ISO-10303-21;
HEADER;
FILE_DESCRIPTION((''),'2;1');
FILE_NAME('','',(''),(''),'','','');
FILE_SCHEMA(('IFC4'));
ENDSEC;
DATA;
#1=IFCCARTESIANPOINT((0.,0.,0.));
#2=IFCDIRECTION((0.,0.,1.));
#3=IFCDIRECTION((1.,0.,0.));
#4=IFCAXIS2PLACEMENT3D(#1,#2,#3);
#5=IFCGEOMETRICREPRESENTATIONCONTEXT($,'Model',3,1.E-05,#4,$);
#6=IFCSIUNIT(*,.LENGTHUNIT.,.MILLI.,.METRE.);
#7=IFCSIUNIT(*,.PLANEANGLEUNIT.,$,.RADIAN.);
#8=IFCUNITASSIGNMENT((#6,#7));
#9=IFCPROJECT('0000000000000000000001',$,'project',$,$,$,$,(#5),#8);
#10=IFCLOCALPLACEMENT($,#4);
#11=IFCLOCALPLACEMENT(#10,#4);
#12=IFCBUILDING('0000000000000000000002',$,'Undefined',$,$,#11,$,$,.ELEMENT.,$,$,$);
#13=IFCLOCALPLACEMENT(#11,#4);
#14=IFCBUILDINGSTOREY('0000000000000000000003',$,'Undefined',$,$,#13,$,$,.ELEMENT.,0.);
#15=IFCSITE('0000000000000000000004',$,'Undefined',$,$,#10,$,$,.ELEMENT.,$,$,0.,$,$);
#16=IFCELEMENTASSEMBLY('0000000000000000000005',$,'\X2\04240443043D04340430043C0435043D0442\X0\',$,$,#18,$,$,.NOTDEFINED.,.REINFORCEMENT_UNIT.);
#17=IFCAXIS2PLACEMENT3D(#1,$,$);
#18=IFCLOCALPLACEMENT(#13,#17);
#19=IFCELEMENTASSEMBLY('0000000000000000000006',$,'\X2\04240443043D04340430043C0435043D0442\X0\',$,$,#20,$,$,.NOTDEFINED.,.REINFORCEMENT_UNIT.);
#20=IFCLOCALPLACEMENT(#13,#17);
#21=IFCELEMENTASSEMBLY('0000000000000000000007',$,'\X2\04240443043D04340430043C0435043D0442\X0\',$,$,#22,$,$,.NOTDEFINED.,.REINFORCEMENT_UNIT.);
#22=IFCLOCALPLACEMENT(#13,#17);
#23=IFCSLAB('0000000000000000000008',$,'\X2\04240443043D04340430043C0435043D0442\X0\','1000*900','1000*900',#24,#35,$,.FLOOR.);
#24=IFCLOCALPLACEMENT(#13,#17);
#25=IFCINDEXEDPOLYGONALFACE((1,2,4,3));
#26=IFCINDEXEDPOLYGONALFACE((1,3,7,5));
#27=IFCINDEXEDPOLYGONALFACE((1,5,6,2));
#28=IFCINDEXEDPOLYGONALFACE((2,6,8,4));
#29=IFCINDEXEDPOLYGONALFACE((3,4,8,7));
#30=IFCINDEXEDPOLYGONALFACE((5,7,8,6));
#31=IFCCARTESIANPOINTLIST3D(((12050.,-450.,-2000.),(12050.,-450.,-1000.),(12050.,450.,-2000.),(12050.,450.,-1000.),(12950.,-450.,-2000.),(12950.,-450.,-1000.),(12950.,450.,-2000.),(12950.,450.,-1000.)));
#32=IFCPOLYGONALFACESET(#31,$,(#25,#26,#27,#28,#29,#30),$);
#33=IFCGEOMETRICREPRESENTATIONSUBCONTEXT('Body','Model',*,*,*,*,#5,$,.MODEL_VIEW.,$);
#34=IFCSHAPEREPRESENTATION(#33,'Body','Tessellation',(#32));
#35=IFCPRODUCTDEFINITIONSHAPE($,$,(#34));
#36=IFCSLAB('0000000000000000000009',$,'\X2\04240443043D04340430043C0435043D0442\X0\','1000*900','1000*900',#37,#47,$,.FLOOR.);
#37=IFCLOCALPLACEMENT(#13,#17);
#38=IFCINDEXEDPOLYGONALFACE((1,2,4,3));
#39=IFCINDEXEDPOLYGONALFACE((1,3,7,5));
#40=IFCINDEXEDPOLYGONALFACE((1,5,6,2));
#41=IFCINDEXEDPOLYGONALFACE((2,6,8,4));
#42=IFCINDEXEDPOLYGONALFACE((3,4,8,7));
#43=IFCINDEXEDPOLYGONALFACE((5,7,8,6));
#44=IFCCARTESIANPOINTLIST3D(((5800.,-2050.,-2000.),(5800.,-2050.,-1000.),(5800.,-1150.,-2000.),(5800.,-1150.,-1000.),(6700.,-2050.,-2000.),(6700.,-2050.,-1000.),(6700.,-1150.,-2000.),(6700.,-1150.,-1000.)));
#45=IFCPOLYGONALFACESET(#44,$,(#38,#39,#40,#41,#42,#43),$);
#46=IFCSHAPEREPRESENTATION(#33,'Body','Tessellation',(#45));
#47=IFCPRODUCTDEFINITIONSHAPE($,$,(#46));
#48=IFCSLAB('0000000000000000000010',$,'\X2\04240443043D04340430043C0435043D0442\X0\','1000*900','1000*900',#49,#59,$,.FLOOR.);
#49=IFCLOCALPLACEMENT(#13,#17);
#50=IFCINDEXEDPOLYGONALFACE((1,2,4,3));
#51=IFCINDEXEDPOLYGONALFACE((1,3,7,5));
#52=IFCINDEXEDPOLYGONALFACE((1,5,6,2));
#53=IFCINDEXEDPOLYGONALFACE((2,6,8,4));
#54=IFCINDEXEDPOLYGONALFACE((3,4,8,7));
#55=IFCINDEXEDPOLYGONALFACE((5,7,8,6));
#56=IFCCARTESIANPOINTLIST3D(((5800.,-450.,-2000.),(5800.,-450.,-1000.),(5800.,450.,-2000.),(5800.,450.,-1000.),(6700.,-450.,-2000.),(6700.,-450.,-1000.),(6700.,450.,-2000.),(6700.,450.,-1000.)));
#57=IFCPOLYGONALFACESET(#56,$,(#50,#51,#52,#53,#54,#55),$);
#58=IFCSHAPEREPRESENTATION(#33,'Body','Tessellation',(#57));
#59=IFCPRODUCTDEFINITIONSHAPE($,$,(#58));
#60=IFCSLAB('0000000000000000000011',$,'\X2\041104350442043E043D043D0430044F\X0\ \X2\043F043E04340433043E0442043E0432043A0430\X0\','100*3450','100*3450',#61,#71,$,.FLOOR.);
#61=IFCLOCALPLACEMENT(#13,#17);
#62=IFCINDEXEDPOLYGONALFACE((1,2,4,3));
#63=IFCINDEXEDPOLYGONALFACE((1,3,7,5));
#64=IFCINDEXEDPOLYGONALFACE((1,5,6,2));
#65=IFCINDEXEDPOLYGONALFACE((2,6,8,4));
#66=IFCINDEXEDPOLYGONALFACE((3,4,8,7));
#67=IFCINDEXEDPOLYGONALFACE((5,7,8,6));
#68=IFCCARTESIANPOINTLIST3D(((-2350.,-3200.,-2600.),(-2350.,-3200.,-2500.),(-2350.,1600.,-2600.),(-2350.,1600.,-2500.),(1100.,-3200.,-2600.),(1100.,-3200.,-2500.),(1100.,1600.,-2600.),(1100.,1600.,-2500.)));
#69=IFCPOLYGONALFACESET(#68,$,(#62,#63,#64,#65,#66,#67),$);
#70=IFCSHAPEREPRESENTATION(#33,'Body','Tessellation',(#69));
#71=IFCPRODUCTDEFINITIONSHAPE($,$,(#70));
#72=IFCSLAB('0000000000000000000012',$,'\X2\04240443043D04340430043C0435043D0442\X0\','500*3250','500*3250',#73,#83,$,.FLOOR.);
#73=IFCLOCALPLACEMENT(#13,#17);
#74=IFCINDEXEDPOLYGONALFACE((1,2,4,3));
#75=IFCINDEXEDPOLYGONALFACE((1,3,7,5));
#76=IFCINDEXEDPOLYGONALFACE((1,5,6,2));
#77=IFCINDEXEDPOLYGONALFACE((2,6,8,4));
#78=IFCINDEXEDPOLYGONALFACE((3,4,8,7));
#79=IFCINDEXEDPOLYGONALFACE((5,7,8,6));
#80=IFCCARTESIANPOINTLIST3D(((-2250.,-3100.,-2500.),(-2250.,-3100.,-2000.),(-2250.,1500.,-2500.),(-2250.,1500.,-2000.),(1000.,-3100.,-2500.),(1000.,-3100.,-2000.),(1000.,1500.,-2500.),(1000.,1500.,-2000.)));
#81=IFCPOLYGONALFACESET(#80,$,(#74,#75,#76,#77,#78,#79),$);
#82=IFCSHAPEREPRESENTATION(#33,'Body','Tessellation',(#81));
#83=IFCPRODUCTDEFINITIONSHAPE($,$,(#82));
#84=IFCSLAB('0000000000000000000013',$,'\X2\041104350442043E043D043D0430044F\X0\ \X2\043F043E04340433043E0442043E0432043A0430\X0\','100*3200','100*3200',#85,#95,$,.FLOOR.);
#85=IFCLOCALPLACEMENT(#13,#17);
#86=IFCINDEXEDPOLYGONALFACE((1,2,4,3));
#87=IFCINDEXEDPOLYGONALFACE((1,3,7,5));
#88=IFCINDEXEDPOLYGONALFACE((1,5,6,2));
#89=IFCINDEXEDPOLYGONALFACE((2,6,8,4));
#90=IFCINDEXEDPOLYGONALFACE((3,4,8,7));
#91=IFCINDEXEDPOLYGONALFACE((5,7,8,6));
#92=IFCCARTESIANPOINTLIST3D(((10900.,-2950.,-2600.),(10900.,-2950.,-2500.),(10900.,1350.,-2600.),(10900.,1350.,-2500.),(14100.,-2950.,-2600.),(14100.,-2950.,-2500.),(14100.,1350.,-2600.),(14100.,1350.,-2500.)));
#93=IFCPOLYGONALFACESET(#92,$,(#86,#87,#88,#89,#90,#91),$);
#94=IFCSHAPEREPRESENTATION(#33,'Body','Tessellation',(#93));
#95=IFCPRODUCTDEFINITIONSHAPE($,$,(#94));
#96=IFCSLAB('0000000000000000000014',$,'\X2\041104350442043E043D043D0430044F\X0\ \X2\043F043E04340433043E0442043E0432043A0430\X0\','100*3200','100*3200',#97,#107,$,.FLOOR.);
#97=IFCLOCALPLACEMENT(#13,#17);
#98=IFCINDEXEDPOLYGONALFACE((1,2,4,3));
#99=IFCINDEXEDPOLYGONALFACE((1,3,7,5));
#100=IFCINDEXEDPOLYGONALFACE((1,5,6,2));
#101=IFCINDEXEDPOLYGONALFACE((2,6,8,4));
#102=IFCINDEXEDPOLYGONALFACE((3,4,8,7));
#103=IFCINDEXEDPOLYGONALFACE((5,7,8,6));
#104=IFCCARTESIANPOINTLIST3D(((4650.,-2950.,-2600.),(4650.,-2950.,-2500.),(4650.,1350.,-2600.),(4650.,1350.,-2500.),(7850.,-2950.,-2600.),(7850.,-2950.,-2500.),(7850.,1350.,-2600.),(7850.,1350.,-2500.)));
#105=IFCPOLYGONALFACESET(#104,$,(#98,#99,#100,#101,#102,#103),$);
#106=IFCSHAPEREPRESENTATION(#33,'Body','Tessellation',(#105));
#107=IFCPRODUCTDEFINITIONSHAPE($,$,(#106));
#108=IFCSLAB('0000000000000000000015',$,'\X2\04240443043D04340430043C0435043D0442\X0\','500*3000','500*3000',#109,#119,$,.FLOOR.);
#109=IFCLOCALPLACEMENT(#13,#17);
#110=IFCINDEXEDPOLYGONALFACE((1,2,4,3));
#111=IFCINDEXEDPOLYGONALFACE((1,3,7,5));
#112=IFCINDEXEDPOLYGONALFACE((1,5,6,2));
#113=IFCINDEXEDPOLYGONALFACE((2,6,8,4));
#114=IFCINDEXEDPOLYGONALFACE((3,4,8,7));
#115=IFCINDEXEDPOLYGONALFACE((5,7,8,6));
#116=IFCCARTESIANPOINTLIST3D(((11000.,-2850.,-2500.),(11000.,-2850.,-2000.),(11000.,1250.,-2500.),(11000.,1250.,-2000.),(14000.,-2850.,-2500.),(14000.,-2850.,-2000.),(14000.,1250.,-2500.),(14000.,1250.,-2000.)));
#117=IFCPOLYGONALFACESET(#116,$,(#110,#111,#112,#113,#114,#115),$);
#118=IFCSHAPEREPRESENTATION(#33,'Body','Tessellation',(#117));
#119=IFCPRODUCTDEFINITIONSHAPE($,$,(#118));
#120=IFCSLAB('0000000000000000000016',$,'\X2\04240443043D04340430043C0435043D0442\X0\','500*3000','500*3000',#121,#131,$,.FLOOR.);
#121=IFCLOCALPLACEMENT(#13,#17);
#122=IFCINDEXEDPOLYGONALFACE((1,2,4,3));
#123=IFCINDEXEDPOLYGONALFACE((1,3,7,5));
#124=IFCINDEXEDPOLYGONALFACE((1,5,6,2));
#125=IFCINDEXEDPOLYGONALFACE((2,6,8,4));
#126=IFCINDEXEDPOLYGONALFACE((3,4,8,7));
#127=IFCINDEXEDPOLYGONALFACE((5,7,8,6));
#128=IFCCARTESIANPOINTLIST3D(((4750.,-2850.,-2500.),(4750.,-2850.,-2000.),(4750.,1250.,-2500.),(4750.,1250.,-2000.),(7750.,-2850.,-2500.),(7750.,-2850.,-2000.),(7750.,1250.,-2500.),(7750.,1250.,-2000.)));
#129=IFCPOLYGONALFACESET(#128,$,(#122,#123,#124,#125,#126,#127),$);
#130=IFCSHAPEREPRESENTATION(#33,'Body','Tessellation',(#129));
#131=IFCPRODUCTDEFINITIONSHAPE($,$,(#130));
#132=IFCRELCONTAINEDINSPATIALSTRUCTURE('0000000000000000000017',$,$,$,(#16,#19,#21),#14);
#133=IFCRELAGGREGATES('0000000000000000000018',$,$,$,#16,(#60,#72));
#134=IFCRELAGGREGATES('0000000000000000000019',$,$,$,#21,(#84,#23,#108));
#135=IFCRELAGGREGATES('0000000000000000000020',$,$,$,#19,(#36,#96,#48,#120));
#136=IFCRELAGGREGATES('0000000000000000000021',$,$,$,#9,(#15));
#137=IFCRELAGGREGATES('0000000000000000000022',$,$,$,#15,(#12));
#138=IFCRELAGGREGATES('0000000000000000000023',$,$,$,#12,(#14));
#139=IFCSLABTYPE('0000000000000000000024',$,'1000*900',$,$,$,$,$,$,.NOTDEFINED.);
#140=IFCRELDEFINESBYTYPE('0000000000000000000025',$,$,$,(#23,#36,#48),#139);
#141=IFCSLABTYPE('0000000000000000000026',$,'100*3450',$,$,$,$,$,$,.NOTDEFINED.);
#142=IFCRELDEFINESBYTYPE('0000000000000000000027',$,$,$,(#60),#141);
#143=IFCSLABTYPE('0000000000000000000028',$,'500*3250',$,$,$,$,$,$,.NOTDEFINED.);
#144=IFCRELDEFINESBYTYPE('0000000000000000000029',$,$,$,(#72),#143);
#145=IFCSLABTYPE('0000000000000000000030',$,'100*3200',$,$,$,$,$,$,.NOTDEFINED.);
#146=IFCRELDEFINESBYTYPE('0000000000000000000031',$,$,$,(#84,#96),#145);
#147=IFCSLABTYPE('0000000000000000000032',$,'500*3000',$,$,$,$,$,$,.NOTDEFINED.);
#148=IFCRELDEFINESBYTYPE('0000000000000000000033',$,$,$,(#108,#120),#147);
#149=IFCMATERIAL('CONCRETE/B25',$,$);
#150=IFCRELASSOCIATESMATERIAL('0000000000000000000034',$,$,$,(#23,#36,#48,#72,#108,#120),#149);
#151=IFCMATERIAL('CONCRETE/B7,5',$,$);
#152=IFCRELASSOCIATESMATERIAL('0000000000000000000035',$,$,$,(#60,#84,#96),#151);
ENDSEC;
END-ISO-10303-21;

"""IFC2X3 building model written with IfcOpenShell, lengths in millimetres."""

from ifc_helpers import new_model, si_unit, frame, origin_with_axes, place, context, subcontext, project, spatial, polyline, outline, extrude, material, type_object, element, aggregate, save


model = new_model("IFC2X3")

# Units and contexts
model_context = context("Model", 3, precision=1e-05, world=origin_with_axes())
body_context = subcontext(model_context, "Body", "Model", "MODEL_VIEW")
ifc_project = project(units=[si_unit("LENGTHUNIT", "METRE", prefix="MILLI"), si_unit("PLANEANGLEUNIT", "RADIAN")], contexts=[model_context])

# Site, building, storey
site_placement = place(None, origin_with_axes())
site = spatial("IfcSite", under=ifc_project, at=site_placement, Name="Undefined", CompositionType="ELEMENT", RefElevation=0.0)
building_placement = place(site_placement, origin_with_axes())
building = spatial("IfcBuilding", under=site, at=building_placement, Name="Undefined", CompositionType="ELEMENT")
storey_placement = place(building_placement, origin_with_axes())
storey = spatial("IfcBuildingStorey", under=building, at=storey_placement, Name="Undefined", CompositionType="ELEMENT", Elevation=0.0)

# Element assemblies
assembly_1_placement = place(storey_placement, origin_with_axes())
assembly_1 = element("IfcElementAssembly", 1, at=assembly_1_placement, inside=storey, Name="Фундамент", AssemblyPlace="NOTDEFINED", PredefinedType="REINFORCEMENT_UNIT")
ifc_material_1 = material(Name="CONCRETE/B25")
assembly_2_placement = place(storey_placement, origin_with_axes())
assembly_2 = element("IfcElementAssembly", 2, at=assembly_2_placement, inside=storey, Name="Фундамент", AssemblyPlace="NOTDEFINED", PredefinedType="REINFORCEMENT_UNIT")

# Shared definitions
ifc_material_2 = material(Name="CONCRETE/B7,5")

# Shared definitions
slab_type_1 = type_object("IfcSlabType", Name="1000*900", PredefinedType="NOTDEFINED")

# Element assembly, slab
assembly_3_placement = place(storey_placement, origin_with_axes())
assembly_3 = element("IfcElementAssembly", 3, at=assembly_3_placement, inside=storey, Name="Фундамент", AssemblyPlace="NOTDEFINED", PredefinedType="REINFORCEMENT_UNIT")
slab_1_placement = place(assembly_3_placement, frame((12050.0, 450.0, -1500.0), z_axis=(0.0, 0.0, 1.0), x_axis=(0.0, -1.0, 0.0)))
slab_1 = element("IfcSlab", 4, at=slab_1_placement, type_object=slab_type_1, material=ifc_material_1, Name="Фундамент", Description="1000*900", ObjectType="1000*900", PredefinedType="FLOOR", context=body_context, shape_type="SweptSolid", body=[
    extrude(outline(polyline([(0.0, 0.0), (900.0, 0.0), (900.0, 900.0), (0.0, 900.0), (0.0, 0.0)])), frame((0.0, 0.0, -500.0), z_axis=(0.0, 0.0, 1.0), x_axis=(1.0, 0.0, 0.0)), (0.0, 0.0, 1.0), 1000.0),
])

# Slabs
slab_2_placement = place(assembly_2_placement, frame((5800.0, -1150.0, -1500.0), z_axis=(0.0, 0.0, 1.0), x_axis=(0.0, -1.0, 0.0)))
slab_2 = element("IfcSlab", 5, at=slab_2_placement, type_object=slab_type_1, material=ifc_material_1, Name="Фундамент", Description="1000*900", ObjectType="1000*900", PredefinedType="FLOOR", context=body_context, shape_type="SweptSolid", body=[
    extrude(outline(polyline([(0.0, 0.0), (900.0, 0.0), (900.0, 900.0), (0.0, 900.0), (0.0, 0.0)])), frame((0.0, 0.0, -500.0), z_axis=(0.0, 0.0, 1.0), x_axis=(1.0, 0.0, 0.0)), (0.0, 0.0, 1.0), 1000.0),
])
slab_3_placement = place(assembly_2_placement, frame((5800.0, 450.0, -1500.0), z_axis=(0.0, 0.0, 1.0), x_axis=(0.0, -1.0, 0.0)))
slab_3 = element("IfcSlab", 6, at=slab_3_placement, type_object=slab_type_1, material=ifc_material_1, Name="Фундамент", Description="1000*900", ObjectType="1000*900", PredefinedType="FLOOR", context=body_context, shape_type="SweptSolid", body=[
    extrude(outline(polyline([(0.0, 0.0), (900.0, 0.0), (900.0, 900.0), (0.0, 900.0), (0.0, 0.0)])), frame((0.0, 0.0, -500.0), z_axis=(0.0, 0.0, 1.0), x_axis=(1.0, 0.0, 0.0)), (0.0, 0.0, 1.0), 1000.0),
])
slab_type_2 = type_object("IfcSlabType", Name="100*3450", PredefinedType="NOTDEFINED")
slab_4_placement = place(assembly_1_placement, frame((-2350.0, 1600.0, -2550.0), z_axis=(0.0, 0.0, 1.0), x_axis=(0.0, -1.0, 0.0)))
slab_4 = element("IfcSlab", 7, at=slab_4_placement, type_object=slab_type_2, material=ifc_material_2, Name="Бетонная подготовка", Description="100*3450", ObjectType="100*3450", PredefinedType="FLOOR", context=body_context, shape_type="SweptSolid", body=[
    extrude(outline(polyline([(0.0, 0.0), (4800.0, 0.0), (4800.0, 3450.0), (0.0, 3450.0), (0.0, 0.0)])), frame((0.0, 0.0, -50.0), z_axis=(0.0, 0.0, 1.0), x_axis=(1.0, 0.0, 0.0)), (0.0, 0.0, 1.0), 100.0),
])
slab_type_3 = type_object("IfcSlabType", Name="500*3250", PredefinedType="NOTDEFINED")
slab_5_placement = place(assembly_1_placement, frame((-2250.0, 1500.0, -2250.0), z_axis=(0.0, 0.0, 1.0), x_axis=(0.0, -1.0, 0.0)))
slab_5 = element("IfcSlab", 8, at=slab_5_placement, type_object=slab_type_3, material=ifc_material_1, Name="Фундамент", Description="500*3250", ObjectType="500*3250", PredefinedType="FLOOR", context=body_context, shape_type="SweptSolid", body=[
    extrude(outline(polyline([(0.0, 0.0), (4600.0, 0.0), (4600.0, 3250.0), (0.0, 3250.0), (0.0, 0.0)])), frame((0.0, 0.0, -250.0), z_axis=(0.0, 0.0, 1.0), x_axis=(1.0, 0.0, 0.0)), (0.0, 0.0, 1.0), 500.0),
])
aggregate(assembly_1, [slab_4, slab_5])
slab_type_4 = type_object("IfcSlabType", Name="100*3200", PredefinedType="NOTDEFINED")
slab_6_placement = place(assembly_3_placement, frame((10900.0, 1350.0, -2550.0), z_axis=(0.0, 0.0, 1.0), x_axis=(0.0, -1.0, 0.0)))
slab_6 = element("IfcSlab", 9, at=slab_6_placement, type_object=slab_type_4, material=ifc_material_2, Name="Бетонная подготовка", Description="100*3200", ObjectType="100*3200", PredefinedType="FLOOR", context=body_context, shape_type="SweptSolid", body=[
    extrude(outline(polyline([(0.0, 0.0), (4300.0, 0.0), (4300.0, 3200.0), (0.0, 3200.0), (0.0, 0.0)])), frame((0.0, 0.0, -50.0), z_axis=(0.0, 0.0, 1.0), x_axis=(1.0, 0.0, 0.0)), (0.0, 0.0, 1.0), 100.0),
])
slab_7_placement = place(assembly_2_placement, frame((4650.0, 1350.0, -2550.0), z_axis=(0.0, 0.0, 1.0), x_axis=(0.0, -1.0, 0.0)))
slab_7 = element("IfcSlab", 10, at=slab_7_placement, type_object=slab_type_4, material=ifc_material_2, Name="Бетонная подготовка", Description="100*3200", ObjectType="100*3200", PredefinedType="FLOOR", context=body_context, shape_type="SweptSolid", body=[
    extrude(outline(polyline([(0.0, 0.0), (4300.0, 0.0), (4300.0, 3200.0), (0.0, 3200.0), (0.0, 0.0)])), frame((0.0, 0.0, -50.0), z_axis=(0.0, 0.0, 1.0), x_axis=(1.0, 0.0, 0.0)), (0.0, 0.0, 1.0), 100.0),
])
slab_type_5 = type_object("IfcSlabType", Name="500*3000", PredefinedType="NOTDEFINED")
slab_8_placement = place(assembly_3_placement, frame((11000.0, 1250.0, -2250.0), z_axis=(0.0, 0.0, 1.0), x_axis=(0.0, -1.0, 0.0)))
slab_8 = element("IfcSlab", 11, at=slab_8_placement, type_object=slab_type_5, material=ifc_material_1, Name="Фундамент", Description="500*3000", ObjectType="500*3000", PredefinedType="FLOOR", context=body_context, shape_type="SweptSolid", body=[
    extrude(outline(polyline([(0.0, 0.0), (4100.0, 0.0), (4100.0, 3000.0), (0.0, 3000.0), (0.0, 0.0)])), frame((0.0, 0.0, -250.0), z_axis=(0.0, 0.0, 1.0), x_axis=(1.0, 0.0, 0.0)), (0.0, 0.0, 1.0), 500.0),
])
aggregate(assembly_3, [slab_6, slab_1, slab_8])
slab_9_placement = place(assembly_2_placement, frame((4750.0, 1250.0, -2250.0), z_axis=(0.0, 0.0, 1.0), x_axis=(0.0, -1.0, 0.0)))
slab_9 = element("IfcSlab", 12, at=slab_9_placement, type_object=slab_type_5, material=ifc_material_1, Name="Фундамент", Description="500*3000", ObjectType="500*3000", PredefinedType="FLOOR", context=body_context, shape_type="SweptSolid", body=[
    extrude(outline(polyline([(0.0, 0.0), (4100.0, 0.0), (4100.0, 3000.0), (0.0, 3000.0), (0.0, 0.0)])), frame((0.0, 0.0, -250.0), z_axis=(0.0, 0.0, 1.0), x_axis=(1.0, 0.0, 0.0)), (0.0, 0.0, 1.0), 500.0),
])
aggregate(assembly_2, [slab_2, slab_7, slab_3, slab_9])

save(model, "model.ifc")
